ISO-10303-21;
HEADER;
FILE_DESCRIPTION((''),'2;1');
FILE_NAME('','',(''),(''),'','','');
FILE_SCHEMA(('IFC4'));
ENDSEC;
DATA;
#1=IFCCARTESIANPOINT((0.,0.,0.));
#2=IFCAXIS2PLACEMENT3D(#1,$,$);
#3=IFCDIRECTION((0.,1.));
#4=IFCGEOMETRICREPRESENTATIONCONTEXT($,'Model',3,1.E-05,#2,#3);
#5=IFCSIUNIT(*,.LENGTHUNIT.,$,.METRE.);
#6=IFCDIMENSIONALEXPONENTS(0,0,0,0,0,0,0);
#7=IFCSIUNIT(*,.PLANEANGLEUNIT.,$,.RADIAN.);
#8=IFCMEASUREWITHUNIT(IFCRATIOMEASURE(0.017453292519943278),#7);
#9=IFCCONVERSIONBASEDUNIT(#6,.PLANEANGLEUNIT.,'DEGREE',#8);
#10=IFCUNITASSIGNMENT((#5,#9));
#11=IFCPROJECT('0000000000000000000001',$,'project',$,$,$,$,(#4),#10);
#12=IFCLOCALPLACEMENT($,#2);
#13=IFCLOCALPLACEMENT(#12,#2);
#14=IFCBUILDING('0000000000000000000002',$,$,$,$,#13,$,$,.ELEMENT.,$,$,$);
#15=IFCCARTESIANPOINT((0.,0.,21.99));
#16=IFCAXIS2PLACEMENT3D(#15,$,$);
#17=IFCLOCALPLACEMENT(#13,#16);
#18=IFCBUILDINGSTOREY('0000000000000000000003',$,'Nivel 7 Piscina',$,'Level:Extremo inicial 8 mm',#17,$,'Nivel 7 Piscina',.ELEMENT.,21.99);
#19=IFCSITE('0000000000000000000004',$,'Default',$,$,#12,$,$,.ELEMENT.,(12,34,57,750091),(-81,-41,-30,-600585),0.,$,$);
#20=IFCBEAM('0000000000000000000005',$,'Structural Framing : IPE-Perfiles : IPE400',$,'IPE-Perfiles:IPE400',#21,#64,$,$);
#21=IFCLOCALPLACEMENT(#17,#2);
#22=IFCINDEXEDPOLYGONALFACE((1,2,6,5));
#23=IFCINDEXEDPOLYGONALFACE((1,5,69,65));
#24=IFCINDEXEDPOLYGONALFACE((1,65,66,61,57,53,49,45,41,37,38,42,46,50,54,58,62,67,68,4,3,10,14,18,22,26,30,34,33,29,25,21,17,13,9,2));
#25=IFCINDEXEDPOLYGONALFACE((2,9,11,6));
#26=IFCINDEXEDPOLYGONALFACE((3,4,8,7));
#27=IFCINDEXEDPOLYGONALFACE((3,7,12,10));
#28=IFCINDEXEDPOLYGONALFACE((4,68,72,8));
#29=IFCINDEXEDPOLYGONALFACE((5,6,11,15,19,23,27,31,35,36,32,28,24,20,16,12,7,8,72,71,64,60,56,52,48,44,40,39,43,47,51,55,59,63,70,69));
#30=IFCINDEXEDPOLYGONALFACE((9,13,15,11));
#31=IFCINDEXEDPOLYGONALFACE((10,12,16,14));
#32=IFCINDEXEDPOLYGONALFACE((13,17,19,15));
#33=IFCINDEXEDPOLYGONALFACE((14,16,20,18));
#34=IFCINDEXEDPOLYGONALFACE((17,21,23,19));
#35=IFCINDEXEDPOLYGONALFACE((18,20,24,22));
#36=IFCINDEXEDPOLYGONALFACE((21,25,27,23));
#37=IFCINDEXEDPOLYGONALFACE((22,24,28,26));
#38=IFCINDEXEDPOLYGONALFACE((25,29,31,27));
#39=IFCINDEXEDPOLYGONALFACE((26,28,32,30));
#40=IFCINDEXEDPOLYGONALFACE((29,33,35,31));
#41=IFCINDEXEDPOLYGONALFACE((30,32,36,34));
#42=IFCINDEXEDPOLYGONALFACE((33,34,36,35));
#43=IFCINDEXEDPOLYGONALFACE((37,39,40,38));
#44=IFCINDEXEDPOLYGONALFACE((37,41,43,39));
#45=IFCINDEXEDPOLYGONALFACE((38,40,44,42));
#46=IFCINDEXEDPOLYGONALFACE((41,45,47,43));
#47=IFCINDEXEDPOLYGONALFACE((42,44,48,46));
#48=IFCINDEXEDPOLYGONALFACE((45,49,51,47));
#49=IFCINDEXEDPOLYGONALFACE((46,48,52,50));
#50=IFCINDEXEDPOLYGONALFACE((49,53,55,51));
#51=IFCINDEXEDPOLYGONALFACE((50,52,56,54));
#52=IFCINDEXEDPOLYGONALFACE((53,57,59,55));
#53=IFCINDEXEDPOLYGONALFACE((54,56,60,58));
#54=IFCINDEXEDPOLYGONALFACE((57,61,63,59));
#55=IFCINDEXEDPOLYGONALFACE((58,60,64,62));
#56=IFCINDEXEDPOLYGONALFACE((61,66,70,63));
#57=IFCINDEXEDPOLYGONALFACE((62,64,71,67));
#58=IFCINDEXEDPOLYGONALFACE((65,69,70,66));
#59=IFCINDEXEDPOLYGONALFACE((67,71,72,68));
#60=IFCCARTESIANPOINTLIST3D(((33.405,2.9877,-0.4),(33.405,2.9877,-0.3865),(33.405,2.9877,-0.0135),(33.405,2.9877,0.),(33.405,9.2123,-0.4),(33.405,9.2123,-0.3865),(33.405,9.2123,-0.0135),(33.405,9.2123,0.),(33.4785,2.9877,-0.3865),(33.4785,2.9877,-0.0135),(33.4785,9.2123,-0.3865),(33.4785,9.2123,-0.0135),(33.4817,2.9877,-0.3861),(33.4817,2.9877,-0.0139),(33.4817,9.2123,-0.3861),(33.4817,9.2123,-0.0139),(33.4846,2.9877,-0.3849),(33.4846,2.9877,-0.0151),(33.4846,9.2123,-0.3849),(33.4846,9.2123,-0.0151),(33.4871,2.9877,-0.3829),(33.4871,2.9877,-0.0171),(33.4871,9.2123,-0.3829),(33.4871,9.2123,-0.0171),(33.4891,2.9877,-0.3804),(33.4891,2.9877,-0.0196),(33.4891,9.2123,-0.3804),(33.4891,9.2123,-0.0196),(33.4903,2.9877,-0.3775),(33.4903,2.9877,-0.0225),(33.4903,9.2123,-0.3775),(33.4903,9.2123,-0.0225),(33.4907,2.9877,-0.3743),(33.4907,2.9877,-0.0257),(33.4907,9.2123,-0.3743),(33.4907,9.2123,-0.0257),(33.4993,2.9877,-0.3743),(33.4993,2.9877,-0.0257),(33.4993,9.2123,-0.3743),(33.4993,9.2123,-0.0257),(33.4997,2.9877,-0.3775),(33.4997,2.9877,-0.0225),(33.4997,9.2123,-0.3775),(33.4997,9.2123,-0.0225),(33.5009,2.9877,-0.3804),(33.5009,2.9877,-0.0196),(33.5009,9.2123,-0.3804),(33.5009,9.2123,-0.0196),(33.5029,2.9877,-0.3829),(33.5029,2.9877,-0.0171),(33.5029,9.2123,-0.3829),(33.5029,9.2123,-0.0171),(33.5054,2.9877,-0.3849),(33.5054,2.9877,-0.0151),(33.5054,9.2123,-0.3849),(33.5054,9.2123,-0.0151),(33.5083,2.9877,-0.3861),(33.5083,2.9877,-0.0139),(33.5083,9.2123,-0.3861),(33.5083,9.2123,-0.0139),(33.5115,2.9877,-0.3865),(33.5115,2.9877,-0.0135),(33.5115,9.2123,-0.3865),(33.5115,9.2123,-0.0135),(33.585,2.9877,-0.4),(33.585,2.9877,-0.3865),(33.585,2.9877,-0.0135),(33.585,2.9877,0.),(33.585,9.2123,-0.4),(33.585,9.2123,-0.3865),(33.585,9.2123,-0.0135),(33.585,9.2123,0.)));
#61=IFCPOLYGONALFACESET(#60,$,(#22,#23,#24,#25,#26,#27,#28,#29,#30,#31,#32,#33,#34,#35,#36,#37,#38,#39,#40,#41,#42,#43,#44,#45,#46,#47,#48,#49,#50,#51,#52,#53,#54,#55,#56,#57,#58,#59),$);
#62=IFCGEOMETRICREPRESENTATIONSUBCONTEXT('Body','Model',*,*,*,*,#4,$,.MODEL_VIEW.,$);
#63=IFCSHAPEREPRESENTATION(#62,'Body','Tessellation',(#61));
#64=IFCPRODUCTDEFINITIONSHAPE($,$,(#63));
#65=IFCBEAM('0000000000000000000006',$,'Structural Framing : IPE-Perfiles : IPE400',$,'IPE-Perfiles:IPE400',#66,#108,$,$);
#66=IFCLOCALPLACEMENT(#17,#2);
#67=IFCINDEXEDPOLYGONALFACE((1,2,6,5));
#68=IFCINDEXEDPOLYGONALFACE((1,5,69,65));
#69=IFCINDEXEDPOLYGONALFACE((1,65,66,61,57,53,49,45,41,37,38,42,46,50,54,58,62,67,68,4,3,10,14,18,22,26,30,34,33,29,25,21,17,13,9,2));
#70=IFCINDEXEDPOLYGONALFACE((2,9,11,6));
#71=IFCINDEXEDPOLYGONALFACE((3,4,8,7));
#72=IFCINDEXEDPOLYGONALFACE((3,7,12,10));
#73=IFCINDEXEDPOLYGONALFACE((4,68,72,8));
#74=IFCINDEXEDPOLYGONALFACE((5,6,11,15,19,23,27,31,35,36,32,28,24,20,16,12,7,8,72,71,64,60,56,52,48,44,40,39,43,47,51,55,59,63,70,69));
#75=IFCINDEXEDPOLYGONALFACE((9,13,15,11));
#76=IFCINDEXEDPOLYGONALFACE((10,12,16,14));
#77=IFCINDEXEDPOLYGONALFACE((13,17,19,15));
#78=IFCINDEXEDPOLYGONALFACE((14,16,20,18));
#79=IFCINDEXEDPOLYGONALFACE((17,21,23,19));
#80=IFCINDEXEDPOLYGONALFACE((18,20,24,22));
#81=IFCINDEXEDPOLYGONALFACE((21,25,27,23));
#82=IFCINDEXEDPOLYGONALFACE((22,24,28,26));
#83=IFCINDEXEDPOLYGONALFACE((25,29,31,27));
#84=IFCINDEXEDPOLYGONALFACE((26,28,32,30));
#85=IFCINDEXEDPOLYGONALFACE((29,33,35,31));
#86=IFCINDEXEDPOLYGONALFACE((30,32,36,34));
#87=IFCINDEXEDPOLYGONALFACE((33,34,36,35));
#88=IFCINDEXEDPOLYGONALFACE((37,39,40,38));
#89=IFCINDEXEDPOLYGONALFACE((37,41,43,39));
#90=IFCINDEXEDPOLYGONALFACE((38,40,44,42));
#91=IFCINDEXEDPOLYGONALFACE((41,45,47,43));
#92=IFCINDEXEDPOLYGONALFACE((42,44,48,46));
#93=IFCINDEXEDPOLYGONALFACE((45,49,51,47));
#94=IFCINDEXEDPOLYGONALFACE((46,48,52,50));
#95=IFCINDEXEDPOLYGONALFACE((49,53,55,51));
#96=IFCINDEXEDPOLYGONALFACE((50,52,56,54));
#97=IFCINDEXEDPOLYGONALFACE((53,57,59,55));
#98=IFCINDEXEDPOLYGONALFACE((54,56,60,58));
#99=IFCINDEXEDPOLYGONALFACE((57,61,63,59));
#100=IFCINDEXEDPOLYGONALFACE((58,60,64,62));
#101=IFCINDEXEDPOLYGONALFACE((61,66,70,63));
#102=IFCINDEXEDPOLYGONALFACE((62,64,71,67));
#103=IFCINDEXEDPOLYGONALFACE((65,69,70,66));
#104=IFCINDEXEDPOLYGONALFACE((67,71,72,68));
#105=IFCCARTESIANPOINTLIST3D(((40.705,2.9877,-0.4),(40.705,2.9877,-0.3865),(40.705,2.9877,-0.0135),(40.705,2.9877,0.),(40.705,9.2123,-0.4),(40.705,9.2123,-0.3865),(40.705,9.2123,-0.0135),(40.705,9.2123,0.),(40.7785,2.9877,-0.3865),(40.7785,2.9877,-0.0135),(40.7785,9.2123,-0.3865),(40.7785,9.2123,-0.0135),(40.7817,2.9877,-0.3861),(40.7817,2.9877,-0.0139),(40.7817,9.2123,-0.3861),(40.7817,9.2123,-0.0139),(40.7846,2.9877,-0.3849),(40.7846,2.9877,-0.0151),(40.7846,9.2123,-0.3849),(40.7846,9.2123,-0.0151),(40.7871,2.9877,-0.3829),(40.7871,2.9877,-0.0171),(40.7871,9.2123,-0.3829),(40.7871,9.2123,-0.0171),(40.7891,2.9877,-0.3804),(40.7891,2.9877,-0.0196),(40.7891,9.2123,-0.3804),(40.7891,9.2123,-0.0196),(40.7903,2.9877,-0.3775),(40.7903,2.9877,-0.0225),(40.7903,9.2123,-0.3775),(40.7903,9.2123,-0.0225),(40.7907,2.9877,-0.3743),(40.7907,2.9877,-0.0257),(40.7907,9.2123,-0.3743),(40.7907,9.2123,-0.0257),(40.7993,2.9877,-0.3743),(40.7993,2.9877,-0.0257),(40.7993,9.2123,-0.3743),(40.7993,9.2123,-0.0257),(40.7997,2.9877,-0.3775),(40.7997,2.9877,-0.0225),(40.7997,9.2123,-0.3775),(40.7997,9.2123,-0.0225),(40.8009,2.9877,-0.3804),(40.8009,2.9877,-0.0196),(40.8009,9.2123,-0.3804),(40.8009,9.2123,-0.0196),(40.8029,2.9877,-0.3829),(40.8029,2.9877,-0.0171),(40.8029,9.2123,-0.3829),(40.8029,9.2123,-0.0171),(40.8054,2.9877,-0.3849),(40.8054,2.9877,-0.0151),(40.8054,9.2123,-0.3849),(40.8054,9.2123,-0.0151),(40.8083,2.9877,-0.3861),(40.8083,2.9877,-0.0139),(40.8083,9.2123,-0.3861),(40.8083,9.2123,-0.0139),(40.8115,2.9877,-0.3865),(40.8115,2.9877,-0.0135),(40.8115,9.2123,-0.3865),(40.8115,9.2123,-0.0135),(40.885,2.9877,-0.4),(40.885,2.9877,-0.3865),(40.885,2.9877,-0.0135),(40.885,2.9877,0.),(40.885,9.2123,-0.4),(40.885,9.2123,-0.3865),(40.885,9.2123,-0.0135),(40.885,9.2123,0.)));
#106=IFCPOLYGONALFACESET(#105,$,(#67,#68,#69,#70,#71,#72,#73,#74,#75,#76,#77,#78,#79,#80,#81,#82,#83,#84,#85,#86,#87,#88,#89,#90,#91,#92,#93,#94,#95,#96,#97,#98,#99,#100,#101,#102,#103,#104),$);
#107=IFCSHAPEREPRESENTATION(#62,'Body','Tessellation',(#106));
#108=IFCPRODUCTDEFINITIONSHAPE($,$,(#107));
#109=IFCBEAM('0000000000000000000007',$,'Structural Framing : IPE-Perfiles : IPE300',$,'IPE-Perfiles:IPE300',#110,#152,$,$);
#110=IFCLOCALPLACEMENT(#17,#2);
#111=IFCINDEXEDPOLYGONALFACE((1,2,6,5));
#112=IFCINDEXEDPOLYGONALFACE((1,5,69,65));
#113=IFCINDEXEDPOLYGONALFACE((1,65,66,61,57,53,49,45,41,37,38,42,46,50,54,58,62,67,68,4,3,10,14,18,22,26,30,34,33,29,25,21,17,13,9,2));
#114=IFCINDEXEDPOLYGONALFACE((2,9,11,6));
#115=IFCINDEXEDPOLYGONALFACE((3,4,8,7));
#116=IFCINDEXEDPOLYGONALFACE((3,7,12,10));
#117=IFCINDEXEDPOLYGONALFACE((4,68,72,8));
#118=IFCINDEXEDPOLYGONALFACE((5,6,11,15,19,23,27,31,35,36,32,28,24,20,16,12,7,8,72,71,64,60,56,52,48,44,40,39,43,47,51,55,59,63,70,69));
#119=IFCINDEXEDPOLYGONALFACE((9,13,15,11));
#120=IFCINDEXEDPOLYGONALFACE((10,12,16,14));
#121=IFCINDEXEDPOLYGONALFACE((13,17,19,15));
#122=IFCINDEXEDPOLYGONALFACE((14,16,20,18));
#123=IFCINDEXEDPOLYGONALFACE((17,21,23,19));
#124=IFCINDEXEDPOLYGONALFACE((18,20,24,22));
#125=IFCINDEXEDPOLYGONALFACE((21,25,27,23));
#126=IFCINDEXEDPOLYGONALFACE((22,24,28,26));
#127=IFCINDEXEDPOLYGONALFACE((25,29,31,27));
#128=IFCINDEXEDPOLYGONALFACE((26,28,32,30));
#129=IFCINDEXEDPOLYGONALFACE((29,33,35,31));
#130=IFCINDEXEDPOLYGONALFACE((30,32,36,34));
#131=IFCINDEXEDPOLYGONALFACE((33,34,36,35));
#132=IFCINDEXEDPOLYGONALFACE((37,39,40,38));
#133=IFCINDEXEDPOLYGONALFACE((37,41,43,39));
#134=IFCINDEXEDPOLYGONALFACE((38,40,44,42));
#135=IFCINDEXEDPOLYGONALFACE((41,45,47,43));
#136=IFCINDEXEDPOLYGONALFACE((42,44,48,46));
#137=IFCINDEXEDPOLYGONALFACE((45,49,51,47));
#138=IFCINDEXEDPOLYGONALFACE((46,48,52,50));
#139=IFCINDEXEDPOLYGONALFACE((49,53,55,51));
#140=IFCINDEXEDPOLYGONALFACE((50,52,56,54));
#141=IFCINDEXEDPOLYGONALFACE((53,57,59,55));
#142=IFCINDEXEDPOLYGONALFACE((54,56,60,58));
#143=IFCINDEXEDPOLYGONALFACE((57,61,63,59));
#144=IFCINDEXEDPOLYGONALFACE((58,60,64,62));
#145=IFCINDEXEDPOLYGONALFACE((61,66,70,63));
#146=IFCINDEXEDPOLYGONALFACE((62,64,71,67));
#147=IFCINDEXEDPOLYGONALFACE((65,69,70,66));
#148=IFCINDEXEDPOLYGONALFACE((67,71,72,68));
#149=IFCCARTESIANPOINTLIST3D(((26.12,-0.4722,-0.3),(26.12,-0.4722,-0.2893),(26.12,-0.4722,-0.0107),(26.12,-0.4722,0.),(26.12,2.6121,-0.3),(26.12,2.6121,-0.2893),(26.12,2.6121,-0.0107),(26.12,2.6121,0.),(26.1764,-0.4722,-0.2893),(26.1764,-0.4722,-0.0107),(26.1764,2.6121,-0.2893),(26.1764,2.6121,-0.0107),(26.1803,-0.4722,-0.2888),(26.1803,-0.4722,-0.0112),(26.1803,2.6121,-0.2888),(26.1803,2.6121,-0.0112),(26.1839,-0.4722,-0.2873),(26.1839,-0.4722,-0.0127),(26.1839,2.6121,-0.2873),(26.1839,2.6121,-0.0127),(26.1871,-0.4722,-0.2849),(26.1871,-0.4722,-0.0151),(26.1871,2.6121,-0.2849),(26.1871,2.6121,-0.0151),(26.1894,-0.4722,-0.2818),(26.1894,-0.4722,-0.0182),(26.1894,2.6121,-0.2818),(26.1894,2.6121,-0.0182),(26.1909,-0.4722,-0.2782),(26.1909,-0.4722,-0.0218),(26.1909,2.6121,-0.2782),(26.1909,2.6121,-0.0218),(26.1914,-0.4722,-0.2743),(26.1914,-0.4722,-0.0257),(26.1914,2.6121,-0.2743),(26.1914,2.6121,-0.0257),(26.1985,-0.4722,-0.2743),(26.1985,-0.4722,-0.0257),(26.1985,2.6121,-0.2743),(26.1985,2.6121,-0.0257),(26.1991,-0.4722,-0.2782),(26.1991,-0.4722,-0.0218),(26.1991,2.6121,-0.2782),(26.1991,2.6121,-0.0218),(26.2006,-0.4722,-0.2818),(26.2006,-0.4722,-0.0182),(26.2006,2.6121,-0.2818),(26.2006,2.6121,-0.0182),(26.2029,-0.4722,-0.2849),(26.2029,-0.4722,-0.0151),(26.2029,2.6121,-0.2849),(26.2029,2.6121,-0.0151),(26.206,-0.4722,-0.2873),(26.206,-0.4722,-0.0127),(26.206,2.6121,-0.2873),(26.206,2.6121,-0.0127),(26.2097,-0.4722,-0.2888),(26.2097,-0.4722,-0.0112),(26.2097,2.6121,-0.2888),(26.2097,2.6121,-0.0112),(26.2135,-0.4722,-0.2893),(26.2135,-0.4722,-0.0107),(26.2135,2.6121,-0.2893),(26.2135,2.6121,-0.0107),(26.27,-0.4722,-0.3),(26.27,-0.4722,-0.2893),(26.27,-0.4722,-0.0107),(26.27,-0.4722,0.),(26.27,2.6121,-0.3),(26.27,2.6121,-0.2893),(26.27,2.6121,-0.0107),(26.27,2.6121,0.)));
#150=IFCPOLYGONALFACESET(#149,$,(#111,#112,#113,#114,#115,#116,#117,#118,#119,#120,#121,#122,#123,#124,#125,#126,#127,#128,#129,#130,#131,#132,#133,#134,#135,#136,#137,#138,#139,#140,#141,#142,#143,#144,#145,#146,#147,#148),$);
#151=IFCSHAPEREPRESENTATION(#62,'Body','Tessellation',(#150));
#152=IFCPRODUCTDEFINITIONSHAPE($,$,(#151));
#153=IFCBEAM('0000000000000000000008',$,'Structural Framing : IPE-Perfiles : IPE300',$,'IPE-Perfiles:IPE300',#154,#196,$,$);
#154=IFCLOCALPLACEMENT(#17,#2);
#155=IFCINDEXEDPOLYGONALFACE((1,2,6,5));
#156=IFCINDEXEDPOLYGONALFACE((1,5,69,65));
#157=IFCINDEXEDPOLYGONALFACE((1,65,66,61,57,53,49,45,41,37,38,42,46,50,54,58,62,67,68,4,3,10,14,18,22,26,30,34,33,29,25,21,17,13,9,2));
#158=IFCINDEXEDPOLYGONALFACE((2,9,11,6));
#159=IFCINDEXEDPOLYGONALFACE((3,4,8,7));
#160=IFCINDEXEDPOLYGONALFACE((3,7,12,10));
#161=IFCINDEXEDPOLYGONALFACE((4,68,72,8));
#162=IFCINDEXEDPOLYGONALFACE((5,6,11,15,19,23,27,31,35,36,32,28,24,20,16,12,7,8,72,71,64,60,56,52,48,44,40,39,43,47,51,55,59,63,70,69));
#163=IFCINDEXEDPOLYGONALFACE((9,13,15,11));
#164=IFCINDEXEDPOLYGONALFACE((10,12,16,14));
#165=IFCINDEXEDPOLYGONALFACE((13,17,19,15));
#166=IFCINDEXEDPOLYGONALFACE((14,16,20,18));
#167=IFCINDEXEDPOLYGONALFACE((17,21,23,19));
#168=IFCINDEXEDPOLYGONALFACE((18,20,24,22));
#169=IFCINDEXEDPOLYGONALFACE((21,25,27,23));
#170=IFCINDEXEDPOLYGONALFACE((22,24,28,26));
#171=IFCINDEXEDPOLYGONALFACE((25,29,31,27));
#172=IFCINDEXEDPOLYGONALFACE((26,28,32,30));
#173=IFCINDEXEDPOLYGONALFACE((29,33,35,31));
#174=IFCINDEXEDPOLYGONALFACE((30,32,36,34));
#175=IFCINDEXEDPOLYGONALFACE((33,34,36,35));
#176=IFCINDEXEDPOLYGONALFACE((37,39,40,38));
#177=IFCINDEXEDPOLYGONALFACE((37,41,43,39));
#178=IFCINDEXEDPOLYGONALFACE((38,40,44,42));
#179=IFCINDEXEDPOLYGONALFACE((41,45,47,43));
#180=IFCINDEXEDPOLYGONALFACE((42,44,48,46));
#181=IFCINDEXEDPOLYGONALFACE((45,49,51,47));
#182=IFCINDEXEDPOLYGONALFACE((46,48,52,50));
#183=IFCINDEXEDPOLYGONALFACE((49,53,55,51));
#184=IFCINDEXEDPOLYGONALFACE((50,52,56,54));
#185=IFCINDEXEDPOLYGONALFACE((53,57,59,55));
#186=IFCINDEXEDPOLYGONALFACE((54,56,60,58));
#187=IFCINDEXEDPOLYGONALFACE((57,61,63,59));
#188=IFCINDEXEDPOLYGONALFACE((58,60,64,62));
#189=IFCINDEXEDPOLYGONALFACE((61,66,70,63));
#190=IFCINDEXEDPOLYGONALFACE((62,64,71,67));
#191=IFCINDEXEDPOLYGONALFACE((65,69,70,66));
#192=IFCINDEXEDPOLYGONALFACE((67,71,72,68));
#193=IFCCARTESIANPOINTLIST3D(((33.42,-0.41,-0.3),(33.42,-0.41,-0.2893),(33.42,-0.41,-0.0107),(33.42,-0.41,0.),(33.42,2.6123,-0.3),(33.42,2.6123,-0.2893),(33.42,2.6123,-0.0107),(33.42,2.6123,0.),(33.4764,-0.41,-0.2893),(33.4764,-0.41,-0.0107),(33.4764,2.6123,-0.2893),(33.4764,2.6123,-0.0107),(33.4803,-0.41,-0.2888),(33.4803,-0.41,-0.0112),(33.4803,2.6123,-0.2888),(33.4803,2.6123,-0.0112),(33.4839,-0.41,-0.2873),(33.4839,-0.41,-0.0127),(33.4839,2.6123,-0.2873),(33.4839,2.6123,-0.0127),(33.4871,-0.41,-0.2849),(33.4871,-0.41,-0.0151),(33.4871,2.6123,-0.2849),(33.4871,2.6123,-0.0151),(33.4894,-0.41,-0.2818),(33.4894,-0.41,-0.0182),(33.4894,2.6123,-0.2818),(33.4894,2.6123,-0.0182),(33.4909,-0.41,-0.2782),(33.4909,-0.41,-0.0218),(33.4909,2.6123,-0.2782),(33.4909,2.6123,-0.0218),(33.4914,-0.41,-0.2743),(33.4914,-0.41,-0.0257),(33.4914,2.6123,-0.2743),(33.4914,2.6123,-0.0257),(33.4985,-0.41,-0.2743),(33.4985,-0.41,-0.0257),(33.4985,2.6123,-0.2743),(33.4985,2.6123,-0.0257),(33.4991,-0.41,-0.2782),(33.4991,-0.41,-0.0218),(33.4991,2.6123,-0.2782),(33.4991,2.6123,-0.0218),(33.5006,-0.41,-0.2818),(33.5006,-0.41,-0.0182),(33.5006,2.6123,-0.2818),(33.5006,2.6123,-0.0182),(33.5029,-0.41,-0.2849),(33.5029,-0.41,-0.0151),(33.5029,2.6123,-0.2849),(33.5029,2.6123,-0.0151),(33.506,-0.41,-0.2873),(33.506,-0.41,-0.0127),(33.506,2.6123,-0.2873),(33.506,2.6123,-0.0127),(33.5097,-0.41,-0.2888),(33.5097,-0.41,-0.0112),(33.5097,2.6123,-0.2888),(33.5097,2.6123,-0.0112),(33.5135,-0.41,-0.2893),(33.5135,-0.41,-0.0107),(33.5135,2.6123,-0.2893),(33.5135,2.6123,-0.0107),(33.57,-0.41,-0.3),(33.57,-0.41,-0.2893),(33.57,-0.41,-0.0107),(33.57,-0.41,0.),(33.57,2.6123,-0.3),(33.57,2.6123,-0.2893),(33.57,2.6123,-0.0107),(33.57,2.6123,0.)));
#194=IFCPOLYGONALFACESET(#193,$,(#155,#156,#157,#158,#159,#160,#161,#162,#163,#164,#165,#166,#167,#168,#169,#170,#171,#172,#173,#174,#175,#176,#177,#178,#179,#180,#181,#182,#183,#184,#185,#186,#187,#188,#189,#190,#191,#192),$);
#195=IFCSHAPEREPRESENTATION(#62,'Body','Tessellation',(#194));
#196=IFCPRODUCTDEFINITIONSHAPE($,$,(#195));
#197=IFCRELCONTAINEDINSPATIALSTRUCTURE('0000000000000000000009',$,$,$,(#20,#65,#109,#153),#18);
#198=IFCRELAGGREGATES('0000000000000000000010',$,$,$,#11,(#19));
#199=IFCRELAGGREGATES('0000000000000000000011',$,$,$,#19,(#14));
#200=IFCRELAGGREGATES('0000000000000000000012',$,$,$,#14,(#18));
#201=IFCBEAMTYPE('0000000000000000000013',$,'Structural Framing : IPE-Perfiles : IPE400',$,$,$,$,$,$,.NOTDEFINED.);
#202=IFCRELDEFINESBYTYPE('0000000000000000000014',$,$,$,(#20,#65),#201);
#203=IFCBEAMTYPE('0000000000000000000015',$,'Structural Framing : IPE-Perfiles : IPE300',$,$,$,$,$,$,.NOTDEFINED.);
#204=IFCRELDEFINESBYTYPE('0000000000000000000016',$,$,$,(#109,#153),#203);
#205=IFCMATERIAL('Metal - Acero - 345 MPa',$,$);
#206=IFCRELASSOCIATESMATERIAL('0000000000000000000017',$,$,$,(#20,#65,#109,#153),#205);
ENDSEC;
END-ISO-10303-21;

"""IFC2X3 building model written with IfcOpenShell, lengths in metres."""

from ifc_helpers import new_model, entity, si_unit, converted_unit, direction, frame, frame_2d, origin, place, context, subcontext, project, spatial, i_section, extrude, material, type_object, element, save


model = new_model("IFC2X3")

# Units and contexts
model_context = context("Model", 3, precision=1e-05, world=origin(), true_north=direction((0.0, 1.0)))
body_context = subcontext(model_context, "Body", "Model", "MODEL_VIEW")
ifc_project = project(units=[si_unit("LENGTHUNIT", "METRE"), converted_unit("PLANEANGLEUNIT", "DEGREE", entity("IfcRatioMeasure", 0.017453292519943278), si_unit("PLANEANGLEUNIT", "RADIAN"), dimensions=[0, 0, 0, 0, 0, 0, 0])], contexts=[model_context])

# Site, building, storey
site_placement = place(None, origin())
site = spatial("IfcSite", under=ifc_project, at=site_placement, Name="Default", CompositionType="ELEMENT", RefLatitude=(12, 34, 57, 750091), RefLongitude=(-81, -41, -30, -600585), RefElevation=0.0)
building_placement = place(site_placement, origin())
building = spatial("IfcBuilding", under=site, at=building_placement, CompositionType="ELEMENT")
storey_placement = place(building_placement, frame((0.0, 0.0, 21.99)))
storey = spatial("IfcBuildingStorey", under=building, at=storey_placement, Name="Nivel 7 Piscina", ObjectType="Level:Extremo inicial 8 mm", LongName="Nivel 7 Piscina", CompositionType="ELEMENT", Elevation=21.99)

# Shared definitions
ifc_material = material(Name="Metal - Acero - 345 MPa")

# Beams
beam_type_1 = type_object("IfcBeamType", Name="Structural Framing : IPE-Perfiles : IPE400", PredefinedType="NOTDEFINED")
beam_1_placement = place(storey_placement, frame((33.495, 2.995, 0.0), z_axis=(0.0, 0.0, 1.0), x_axis=(0.0, 1.0, 0.0)))
element("IfcBeam", 1, at=beam_1_placement, inside=storey, type_object=beam_type_1, material=ifc_material, Name="Structural Framing : IPE-Perfiles : IPE400", ObjectType="IPE-Perfiles:IPE400", context=body_context, shape_type="SweptSolid", body=[
    extrude(i_section(OverallWidth=0.18, OverallDepth=0.4, WebThickness=0.0086, FlangeThickness=0.0135, FilletRadius=0.0122, at=frame_2d((0.0, 0.0), x_axis=(0.0, 1.0))), frame((-0.0073, 0.0, -0.2), z_axis=(1.0, 0.0, 0.0), x_axis=(0.0, 0.0, -1.0)), (0.0, 0.0, 1.0), 6.2246),
])
beam_2_placement = place(storey_placement, frame((40.795, 2.995, 0.0), z_axis=(0.0, 0.0, 1.0), x_axis=(0.0, 1.0, 0.0)))
element("IfcBeam", 2, at=beam_2_placement, inside=storey, type_object=beam_type_1, material=ifc_material, Name="Structural Framing : IPE-Perfiles : IPE400", ObjectType="IPE-Perfiles:IPE400", context=body_context, shape_type="SweptSolid", body=[
    extrude(i_section(OverallWidth=0.18, OverallDepth=0.4, WebThickness=0.0086, FlangeThickness=0.0135, FilletRadius=0.0122, at=frame_2d((0.0, 0.0), x_axis=(0.0, 1.0))), frame((-0.0073, 0.0, -0.2), z_axis=(1.0, 0.0, 0.0), x_axis=(0.0, 0.0, -1.0)), (0.0, 0.0, 1.0), 6.2246),
])
beam_type_2 = type_object("IfcBeamType", Name="Structural Framing : IPE-Perfiles : IPE300", PredefinedType="NOTDEFINED")
beam_3_placement = place(storey_placement, frame((26.195, -0.4123, 0.0), z_axis=(0.0, 0.0, 1.0), x_axis=(0.0, 1.0, 0.0)))
element("IfcBeam", 3, at=beam_3_placement, inside=storey, type_object=beam_type_2, material=ifc_material, Name="Structural Framing : IPE-Perfiles : IPE300", ObjectType="IPE-Perfiles:IPE300", context=body_context, shape_type="SweptSolid", body=[
    extrude(i_section(OverallWidth=0.15, OverallDepth=0.3, WebThickness=0.0071, FlangeThickness=0.0107, FilletRadius=0.015, at=frame_2d((0.0, 0.0), x_axis=(0.0, 1.0))), frame((-0.0598, 0.0, -0.15), z_axis=(1.0, 0.0, 0.0), x_axis=(0.0, 0.0, -1.0)), (0.0, 0.0, 1.0), 3.0843),
])
beam_4_placement = place(storey_placement, frame((33.495, -0.35, 0.0), z_axis=(0.0, 0.0, 1.0), x_axis=(0.0, 1.0, 0.0)))
element("IfcBeam", 4, at=beam_4_placement, inside=storey, type_object=beam_type_2, material=ifc_material, Name="Structural Framing : IPE-Perfiles : IPE300", ObjectType="IPE-Perfiles:IPE300", context=body_context, shape_type="SweptSolid", body=[
    extrude(i_section(OverallWidth=0.15, OverallDepth=0.3, WebThickness=0.0071, FlangeThickness=0.0107, FilletRadius=0.015, at=frame_2d((0.0, 0.0), x_axis=(0.0, 1.0))), frame((-0.06, 0.0, -0.15), z_axis=(1.0, 0.0, 0.0), x_axis=(0.0, 0.0, -1.0)), (0.0, 0.0, 1.0), 3.0223),
])

save(model, "model.ifc")
